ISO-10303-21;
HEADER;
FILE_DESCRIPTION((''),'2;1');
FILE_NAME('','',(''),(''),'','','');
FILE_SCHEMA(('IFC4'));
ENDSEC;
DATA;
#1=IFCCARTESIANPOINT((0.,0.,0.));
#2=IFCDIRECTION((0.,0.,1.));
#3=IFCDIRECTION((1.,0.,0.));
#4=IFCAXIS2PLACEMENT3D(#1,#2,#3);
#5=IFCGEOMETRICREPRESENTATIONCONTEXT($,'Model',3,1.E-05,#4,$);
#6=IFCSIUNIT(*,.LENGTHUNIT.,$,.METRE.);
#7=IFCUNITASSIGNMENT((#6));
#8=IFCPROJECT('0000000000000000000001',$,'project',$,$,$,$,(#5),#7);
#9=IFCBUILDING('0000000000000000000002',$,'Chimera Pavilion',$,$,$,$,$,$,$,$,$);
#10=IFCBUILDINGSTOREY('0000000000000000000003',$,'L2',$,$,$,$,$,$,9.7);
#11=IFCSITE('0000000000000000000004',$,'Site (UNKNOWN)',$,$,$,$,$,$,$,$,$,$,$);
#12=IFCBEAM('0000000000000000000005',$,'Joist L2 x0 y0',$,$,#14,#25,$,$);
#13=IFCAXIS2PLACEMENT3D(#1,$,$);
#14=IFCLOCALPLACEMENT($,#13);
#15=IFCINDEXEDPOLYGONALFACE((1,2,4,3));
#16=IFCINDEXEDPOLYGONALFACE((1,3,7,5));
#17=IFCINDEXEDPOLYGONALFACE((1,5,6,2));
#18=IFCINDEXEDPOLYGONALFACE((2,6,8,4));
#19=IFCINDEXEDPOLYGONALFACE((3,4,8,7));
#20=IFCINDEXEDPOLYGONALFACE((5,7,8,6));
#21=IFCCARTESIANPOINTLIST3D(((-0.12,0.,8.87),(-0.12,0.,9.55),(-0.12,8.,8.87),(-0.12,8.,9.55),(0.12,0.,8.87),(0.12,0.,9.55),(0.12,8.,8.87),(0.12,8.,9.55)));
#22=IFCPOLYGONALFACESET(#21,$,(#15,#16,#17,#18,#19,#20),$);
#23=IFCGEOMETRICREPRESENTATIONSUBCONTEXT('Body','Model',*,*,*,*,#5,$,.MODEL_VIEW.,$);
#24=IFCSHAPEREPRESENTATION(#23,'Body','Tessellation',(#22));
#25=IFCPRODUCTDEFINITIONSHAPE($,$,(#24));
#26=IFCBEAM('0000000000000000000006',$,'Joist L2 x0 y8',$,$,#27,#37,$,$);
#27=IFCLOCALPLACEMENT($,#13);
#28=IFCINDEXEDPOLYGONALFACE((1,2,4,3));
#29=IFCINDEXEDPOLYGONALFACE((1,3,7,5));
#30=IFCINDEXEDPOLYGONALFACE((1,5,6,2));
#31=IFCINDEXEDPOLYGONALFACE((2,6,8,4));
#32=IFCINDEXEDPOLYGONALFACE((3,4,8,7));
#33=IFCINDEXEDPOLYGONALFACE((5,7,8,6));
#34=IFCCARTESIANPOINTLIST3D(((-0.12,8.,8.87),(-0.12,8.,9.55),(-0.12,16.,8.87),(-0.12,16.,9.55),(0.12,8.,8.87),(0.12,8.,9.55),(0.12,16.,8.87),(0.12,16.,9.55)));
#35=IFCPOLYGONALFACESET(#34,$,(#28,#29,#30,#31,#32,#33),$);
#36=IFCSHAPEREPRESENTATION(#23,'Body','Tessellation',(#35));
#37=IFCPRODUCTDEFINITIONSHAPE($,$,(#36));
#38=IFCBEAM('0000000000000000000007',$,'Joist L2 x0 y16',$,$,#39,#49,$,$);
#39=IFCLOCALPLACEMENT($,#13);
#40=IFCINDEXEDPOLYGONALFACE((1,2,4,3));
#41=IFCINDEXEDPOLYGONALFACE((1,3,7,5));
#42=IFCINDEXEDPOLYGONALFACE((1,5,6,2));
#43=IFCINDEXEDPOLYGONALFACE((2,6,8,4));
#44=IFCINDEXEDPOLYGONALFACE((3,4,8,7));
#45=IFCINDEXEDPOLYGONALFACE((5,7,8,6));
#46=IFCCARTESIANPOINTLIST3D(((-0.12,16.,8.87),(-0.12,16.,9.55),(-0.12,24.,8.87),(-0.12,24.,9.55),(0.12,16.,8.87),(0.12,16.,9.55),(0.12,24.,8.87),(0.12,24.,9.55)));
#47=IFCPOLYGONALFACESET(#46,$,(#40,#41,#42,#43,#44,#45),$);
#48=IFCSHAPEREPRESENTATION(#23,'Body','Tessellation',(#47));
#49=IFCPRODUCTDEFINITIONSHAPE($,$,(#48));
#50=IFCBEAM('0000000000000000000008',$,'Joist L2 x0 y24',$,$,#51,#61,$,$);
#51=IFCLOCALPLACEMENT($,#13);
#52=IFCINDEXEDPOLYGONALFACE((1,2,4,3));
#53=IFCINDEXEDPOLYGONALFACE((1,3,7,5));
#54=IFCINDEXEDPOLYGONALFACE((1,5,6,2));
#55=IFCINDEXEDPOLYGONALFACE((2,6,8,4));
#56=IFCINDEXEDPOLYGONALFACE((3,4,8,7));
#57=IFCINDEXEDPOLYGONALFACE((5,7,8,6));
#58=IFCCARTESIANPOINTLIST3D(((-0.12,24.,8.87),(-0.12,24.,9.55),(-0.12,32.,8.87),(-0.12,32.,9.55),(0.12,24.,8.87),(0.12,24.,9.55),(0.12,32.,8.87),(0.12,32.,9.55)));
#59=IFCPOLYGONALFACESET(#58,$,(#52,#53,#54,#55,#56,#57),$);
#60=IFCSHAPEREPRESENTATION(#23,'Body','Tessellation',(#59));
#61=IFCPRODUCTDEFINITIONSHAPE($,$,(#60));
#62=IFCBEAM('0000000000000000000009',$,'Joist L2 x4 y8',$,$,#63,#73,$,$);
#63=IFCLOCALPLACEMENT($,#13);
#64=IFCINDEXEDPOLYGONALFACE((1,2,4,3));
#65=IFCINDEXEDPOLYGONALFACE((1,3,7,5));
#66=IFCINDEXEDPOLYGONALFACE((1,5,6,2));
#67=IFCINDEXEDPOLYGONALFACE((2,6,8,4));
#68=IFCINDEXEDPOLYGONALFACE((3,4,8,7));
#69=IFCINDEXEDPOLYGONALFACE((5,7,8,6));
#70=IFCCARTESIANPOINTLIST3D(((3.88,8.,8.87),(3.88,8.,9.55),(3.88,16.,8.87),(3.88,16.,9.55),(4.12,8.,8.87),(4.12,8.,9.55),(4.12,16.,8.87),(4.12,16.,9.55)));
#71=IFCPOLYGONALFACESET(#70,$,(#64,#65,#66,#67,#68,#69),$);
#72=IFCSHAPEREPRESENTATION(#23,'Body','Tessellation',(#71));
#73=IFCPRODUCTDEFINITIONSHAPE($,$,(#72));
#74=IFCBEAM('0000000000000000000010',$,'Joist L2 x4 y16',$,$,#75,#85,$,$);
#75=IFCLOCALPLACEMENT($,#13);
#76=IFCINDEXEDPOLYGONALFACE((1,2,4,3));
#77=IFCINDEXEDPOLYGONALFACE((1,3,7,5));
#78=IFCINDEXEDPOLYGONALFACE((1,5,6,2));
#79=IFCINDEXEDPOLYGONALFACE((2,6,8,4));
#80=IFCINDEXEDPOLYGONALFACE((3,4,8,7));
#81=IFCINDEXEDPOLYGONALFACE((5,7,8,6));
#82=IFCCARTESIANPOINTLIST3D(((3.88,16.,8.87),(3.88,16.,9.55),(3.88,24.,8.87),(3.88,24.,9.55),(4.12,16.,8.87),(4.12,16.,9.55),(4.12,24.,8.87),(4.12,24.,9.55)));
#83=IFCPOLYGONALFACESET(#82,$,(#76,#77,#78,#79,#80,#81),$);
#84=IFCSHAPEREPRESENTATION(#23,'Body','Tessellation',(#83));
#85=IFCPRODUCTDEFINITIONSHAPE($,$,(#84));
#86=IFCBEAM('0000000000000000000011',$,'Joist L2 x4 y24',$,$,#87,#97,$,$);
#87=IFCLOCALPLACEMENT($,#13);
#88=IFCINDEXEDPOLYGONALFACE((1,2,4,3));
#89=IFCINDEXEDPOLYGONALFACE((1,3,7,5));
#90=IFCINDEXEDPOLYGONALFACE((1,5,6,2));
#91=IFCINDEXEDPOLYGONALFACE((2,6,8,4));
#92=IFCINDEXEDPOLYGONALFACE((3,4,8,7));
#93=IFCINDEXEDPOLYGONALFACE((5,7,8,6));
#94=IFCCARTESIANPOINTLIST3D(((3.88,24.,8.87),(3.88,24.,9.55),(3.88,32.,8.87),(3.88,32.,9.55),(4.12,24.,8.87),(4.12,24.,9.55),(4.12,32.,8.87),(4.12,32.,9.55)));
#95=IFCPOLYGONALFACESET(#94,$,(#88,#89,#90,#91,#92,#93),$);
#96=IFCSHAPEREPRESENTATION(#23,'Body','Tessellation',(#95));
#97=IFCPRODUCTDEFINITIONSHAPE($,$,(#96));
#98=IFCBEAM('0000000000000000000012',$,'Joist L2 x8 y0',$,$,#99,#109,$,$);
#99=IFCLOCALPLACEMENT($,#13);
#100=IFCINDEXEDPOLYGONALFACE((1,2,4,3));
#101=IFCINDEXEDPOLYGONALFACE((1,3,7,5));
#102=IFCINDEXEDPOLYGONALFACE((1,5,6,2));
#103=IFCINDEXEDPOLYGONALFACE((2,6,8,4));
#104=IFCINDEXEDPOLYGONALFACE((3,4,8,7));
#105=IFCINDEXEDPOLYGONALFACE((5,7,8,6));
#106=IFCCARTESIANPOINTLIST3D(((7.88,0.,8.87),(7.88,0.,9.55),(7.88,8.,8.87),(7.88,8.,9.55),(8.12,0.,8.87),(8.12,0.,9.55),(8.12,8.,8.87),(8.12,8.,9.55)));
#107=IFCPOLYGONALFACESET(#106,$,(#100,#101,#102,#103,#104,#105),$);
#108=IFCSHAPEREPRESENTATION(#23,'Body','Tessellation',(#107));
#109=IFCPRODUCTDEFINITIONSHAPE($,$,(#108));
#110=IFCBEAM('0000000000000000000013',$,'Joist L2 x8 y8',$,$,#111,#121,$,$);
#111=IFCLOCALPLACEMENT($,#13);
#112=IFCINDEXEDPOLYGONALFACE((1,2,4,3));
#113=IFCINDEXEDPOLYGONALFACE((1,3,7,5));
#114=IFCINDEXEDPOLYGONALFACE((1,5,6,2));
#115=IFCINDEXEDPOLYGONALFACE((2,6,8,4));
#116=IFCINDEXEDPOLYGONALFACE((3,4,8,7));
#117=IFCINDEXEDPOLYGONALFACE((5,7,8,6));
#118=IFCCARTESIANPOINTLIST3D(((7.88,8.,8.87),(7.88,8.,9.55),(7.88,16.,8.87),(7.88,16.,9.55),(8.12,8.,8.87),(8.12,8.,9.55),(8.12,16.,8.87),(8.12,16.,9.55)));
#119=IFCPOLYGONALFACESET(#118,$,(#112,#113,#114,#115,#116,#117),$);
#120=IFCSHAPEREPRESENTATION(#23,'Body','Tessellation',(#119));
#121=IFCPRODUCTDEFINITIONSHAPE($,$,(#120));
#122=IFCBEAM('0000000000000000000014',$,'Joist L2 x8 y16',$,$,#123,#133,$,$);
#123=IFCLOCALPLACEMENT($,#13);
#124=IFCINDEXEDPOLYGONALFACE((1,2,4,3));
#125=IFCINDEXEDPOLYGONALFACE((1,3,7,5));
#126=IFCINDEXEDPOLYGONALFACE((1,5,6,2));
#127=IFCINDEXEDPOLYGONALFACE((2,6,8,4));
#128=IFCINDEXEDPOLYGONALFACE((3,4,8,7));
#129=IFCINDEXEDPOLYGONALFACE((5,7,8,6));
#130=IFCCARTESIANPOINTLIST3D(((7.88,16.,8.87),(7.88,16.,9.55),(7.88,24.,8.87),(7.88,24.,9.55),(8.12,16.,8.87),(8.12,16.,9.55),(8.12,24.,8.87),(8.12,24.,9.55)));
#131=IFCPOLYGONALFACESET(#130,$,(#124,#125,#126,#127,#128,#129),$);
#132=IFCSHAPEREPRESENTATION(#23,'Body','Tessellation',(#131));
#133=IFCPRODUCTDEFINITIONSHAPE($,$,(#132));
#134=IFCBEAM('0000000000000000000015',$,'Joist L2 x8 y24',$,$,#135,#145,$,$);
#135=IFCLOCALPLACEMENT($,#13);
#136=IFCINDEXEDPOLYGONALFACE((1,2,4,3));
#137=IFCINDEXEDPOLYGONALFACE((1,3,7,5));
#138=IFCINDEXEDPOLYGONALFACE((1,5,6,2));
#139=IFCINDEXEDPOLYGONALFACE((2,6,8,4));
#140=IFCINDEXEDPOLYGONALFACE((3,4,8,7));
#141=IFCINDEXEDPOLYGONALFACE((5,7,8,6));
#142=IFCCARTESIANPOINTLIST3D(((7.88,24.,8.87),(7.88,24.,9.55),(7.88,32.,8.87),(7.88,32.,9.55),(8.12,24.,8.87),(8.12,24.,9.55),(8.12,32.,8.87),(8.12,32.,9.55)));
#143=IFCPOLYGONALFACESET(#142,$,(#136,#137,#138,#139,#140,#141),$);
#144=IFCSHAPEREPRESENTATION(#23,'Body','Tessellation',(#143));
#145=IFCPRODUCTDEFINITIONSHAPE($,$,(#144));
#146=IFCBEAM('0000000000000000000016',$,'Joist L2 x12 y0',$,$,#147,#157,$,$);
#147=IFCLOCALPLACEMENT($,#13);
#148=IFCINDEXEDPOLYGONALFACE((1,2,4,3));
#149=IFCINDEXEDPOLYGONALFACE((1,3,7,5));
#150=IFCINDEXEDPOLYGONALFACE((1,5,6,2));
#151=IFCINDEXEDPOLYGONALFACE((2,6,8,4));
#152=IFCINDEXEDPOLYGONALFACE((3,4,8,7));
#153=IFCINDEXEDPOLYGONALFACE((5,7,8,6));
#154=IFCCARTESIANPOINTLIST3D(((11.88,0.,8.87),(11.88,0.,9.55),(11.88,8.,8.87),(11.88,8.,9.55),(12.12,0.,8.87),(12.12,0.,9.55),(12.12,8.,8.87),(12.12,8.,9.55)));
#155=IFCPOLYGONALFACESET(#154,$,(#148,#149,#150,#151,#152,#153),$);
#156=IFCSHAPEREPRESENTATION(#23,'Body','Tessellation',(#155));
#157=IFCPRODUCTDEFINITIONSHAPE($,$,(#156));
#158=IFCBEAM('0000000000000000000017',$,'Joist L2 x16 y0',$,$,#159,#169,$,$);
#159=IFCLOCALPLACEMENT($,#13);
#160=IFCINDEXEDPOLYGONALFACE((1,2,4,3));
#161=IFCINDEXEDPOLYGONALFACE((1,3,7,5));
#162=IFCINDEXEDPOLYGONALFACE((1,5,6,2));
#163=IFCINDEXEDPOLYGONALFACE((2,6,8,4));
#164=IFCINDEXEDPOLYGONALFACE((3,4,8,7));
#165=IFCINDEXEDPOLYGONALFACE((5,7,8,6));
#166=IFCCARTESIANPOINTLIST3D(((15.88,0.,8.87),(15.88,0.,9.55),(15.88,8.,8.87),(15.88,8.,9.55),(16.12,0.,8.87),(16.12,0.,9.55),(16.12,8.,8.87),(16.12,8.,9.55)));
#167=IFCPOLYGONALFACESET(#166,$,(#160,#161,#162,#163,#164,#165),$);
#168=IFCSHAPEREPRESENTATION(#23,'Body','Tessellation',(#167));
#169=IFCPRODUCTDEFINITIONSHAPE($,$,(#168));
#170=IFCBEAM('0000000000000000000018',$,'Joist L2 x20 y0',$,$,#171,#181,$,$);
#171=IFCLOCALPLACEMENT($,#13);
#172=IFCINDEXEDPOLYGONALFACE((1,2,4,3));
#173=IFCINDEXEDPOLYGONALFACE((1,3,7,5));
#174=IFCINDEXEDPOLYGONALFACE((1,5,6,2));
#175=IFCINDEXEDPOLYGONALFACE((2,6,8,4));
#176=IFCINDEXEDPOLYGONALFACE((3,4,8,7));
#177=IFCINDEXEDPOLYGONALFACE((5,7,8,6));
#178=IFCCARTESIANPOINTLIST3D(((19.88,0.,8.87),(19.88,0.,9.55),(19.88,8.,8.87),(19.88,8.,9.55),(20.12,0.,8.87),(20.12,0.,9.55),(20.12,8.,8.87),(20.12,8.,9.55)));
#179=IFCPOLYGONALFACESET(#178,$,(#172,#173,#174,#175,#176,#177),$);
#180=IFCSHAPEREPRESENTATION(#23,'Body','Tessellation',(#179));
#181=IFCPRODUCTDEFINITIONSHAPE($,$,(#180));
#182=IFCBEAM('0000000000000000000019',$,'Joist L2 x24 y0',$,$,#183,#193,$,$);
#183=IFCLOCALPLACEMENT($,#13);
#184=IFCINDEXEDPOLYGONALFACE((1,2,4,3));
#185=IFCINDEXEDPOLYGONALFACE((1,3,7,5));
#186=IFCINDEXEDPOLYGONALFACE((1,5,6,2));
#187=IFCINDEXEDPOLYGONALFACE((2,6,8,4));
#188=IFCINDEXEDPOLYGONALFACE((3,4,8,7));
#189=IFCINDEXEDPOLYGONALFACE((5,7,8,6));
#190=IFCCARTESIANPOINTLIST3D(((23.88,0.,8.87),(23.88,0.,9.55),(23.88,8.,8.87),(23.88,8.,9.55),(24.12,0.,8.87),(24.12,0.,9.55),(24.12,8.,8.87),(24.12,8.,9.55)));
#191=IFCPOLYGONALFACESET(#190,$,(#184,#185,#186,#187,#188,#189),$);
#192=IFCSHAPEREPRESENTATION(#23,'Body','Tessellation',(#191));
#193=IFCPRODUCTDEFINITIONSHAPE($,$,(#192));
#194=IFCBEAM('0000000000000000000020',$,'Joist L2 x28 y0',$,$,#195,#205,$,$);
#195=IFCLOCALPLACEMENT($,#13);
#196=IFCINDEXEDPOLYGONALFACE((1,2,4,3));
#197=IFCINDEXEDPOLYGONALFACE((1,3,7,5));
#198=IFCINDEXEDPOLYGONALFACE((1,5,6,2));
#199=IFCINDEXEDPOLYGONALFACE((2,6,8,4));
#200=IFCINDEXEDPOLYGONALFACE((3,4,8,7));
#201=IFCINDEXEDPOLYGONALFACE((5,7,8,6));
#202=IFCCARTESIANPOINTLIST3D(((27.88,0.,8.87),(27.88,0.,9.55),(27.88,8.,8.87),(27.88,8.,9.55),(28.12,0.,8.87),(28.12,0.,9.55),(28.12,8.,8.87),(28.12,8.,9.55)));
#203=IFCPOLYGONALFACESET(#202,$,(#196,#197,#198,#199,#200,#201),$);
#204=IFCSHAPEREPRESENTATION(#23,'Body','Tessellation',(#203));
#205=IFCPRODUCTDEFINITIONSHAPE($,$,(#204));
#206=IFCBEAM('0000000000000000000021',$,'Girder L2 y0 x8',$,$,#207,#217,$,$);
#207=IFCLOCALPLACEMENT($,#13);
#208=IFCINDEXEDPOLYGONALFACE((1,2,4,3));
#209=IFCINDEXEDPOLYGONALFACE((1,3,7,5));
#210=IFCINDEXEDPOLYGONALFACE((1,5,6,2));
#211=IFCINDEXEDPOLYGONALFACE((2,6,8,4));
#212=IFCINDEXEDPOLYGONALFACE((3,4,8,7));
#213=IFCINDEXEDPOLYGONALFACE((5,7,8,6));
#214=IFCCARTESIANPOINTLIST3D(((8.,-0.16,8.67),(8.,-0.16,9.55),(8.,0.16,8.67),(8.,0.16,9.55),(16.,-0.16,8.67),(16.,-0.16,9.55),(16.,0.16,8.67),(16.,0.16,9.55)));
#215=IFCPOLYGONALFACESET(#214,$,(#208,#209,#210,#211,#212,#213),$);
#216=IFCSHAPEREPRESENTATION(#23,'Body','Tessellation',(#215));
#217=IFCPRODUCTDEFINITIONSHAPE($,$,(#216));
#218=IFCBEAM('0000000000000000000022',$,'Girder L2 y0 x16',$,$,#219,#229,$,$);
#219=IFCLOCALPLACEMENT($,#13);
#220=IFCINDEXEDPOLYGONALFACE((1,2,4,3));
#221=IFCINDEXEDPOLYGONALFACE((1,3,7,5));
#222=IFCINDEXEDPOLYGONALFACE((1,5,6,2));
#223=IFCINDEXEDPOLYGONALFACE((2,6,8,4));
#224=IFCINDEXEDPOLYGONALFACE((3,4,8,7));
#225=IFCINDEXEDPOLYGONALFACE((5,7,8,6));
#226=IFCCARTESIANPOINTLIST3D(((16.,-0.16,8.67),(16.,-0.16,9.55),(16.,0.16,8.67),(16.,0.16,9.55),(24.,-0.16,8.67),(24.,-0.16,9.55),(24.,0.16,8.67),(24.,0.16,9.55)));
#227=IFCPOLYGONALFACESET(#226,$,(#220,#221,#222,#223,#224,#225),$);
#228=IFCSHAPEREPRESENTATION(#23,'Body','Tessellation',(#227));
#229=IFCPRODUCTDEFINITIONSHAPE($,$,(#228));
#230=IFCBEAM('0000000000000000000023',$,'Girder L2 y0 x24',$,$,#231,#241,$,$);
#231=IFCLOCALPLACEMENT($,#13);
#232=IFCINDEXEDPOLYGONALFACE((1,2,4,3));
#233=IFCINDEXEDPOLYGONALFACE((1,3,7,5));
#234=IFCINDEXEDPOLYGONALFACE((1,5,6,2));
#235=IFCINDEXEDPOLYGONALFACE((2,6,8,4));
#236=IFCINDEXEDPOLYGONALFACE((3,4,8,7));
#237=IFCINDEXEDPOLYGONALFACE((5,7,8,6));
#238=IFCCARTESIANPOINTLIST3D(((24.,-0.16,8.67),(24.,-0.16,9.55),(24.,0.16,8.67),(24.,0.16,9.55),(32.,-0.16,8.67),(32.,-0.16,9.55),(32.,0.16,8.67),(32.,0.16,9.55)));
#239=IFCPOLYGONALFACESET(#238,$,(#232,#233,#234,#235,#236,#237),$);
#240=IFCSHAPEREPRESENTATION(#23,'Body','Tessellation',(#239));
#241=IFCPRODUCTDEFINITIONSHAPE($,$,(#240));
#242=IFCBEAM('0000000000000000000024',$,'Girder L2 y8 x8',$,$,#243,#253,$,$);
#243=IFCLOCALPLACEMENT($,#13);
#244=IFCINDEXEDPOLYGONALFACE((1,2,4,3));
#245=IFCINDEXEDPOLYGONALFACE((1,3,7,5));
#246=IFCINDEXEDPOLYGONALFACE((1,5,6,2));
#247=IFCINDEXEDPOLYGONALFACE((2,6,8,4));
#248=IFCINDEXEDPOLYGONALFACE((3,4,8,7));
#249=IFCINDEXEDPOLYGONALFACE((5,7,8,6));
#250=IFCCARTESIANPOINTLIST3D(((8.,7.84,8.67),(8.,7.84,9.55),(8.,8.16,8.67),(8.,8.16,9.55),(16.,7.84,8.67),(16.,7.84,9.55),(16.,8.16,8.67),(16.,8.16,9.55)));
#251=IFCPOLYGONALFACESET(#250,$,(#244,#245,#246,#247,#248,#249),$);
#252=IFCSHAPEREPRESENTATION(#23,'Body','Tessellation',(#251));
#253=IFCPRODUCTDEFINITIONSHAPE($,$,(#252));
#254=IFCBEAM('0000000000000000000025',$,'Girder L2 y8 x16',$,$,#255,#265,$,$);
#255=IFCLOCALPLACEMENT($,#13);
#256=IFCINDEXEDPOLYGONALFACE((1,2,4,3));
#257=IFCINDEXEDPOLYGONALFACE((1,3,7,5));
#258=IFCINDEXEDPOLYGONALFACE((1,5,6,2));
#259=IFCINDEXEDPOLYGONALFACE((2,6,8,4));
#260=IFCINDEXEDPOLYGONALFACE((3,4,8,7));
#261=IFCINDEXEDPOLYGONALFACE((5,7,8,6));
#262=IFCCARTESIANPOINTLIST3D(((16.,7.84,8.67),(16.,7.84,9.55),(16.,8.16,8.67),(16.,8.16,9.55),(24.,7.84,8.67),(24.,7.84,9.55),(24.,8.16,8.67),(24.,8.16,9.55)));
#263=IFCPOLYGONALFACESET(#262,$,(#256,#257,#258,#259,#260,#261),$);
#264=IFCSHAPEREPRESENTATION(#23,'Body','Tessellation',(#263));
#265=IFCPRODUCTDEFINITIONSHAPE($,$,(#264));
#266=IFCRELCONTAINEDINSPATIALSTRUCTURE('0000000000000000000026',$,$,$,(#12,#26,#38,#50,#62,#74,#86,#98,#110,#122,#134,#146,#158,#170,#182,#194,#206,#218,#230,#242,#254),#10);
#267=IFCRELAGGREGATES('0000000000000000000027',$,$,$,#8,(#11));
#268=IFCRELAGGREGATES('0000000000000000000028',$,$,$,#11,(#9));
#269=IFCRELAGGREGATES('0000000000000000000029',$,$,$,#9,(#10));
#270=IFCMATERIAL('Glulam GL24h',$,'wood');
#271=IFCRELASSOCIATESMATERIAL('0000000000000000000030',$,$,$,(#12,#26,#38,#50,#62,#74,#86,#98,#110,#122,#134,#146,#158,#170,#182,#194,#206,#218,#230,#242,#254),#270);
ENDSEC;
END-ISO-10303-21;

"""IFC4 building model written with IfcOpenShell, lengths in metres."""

from ifc_helpers import new_model, si_unit, frame, origin_with_axes, place, context, subcontext, project, spatial, rectangle, extrude, material, element, save


model = new_model("IFC4")

# Units and contexts
model_context = context("Model", 3, precision=1e-05, world=origin_with_axes())
body_context = subcontext(model_context, "Body", "Model", "MODEL_VIEW")
ifc_project = project(units=[si_unit("LENGTHUNIT", "METRE")], contexts=[model_context])

# Site, building, storey
site = spatial("IfcSite", under=ifc_project, Name="Site (UNKNOWN)")
building = spatial("IfcBuilding", under=site, Name="Chimera Pavilion")
storey = spatial("IfcBuildingStorey", under=building, Name="L2", Elevation=9.7)

# Beams
ifc_material_1 = material(Name="Glulam GL24h", Category="wood")
for number, where, z_axis, x_axis, name in (
    (1, (0.0, 0.0, 9.21), (0.0, 1.0, 0.0), (1.0, 0.0, 0.0), "Joist L2 x0 y0"),
    (2, (0.0, 8.0, 9.21), (0.0, 1.0, 0.0), (1.0, 0.0, 0.0), "Joist L2 x0 y8"),
    (3, (0.0, 16.0, 9.21), (0.0, 1.0, 0.0), (1.0, 0.0, 0.0), "Joist L2 x0 y16"),
    (4, (0.0, 24.0, 9.21), (0.0, 1.0, 0.0), (1.0, 0.0, 0.0), "Joist L2 x0 y24"),
    (5, (4.0, 8.0, 9.21), (0.0, 1.0, 0.0), (1.0, 0.0, 0.0), "Joist L2 x4 y8"),
    (6, (4.0, 16.0, 9.21), (0.0, 1.0, 0.0), (1.0, 0.0, 0.0), "Joist L2 x4 y16"),
    (7, (4.0, 24.0, 9.21), (0.0, 1.0, 0.0), (1.0, 0.0, 0.0), "Joist L2 x4 y24"),
    (8, (8.0, 0.0, 9.21), (0.0, 1.0, 0.0), (1.0, 0.0, 0.0), "Joist L2 x8 y0"),
    (9, (8.0, 8.0, 9.21), (0.0, 1.0, 0.0), (1.0, 0.0, 0.0), "Joist L2 x8 y8"),
    (10, (8.0, 16.0, 9.21), (0.0, 1.0, 0.0), (1.0, 0.0, 0.0), "Joist L2 x8 y16"),
    (11, (8.0, 24.0, 9.21), (0.0, 1.0, 0.0), (1.0, 0.0, 0.0), "Joist L2 x8 y24"),
    (12, (12.0, 0.0, 9.21), (0.0, 1.0, 0.0), (1.0, 0.0, 0.0), "Joist L2 x12 y0"),
    (13, (16.0, 0.0, 9.21), (0.0, 1.0, 0.0), (1.0, 0.0, 0.0), "Joist L2 x16 y0"),
    (14, (20.0, 0.0, 9.21), (0.0, 1.0, 0.0), (1.0, 0.0, 0.0), "Joist L2 x20 y0"),
    (15, (24.0, 0.0, 9.21), (0.0, 1.0, 0.0), (1.0, 0.0, 0.0), "Joist L2 x24 y0"),
    (16, (28.0, 0.0, 9.21), (0.0, 1.0, 0.0), (1.0, 0.0, 0.0), "Joist L2 x28 y0"),
):
    element("IfcBeam", number, at=place(None, frame(where, z_axis=z_axis, x_axis=x_axis)), inside=storey, material=ifc_material_1, Name=name, context=body_context, shape_type="SweptSolid", body=[
        extrude(rectangle(XDim=0.24, YDim=0.68), origin_with_axes(), (0.0, 0.0, 1.0), 8.0),
    ])
for number, where, z_axis, x_axis, name in (
    (17, (8.0, 0.0, 9.11), (1.0, 0.0, 0.0), (0.0, -1.0, 0.0), "Girder L2 y0 x8"),
    (18, (16.0, 0.0, 9.11), (1.0, 0.0, 0.0), (0.0, -1.0, 0.0), "Girder L2 y0 x16"),
    (19, (24.0, 0.0, 9.11), (1.0, 0.0, 0.0), (0.0, -1.0, 0.0), "Girder L2 y0 x24"),
    (20, (8.0, 8.0, 9.11), (1.0, 0.0, 0.0), (0.0, -1.0, 0.0), "Girder L2 y8 x8"),
    (21, (16.0, 8.0, 9.11), (1.0, 0.0, 0.0), (0.0, -1.0, 0.0), "Girder L2 y8 x16"),
):
    element("IfcBeam", number, at=place(None, frame(where, z_axis=z_axis, x_axis=x_axis)), inside=storey, material=ifc_material_1, Name=name, context=body_context, shape_type="SweptSolid", body=[
        extrude(rectangle(XDim=0.32, YDim=0.88), origin_with_axes(), (0.0, 0.0, 1.0), 8.0),
    ])

save(model, "model.ifc")
